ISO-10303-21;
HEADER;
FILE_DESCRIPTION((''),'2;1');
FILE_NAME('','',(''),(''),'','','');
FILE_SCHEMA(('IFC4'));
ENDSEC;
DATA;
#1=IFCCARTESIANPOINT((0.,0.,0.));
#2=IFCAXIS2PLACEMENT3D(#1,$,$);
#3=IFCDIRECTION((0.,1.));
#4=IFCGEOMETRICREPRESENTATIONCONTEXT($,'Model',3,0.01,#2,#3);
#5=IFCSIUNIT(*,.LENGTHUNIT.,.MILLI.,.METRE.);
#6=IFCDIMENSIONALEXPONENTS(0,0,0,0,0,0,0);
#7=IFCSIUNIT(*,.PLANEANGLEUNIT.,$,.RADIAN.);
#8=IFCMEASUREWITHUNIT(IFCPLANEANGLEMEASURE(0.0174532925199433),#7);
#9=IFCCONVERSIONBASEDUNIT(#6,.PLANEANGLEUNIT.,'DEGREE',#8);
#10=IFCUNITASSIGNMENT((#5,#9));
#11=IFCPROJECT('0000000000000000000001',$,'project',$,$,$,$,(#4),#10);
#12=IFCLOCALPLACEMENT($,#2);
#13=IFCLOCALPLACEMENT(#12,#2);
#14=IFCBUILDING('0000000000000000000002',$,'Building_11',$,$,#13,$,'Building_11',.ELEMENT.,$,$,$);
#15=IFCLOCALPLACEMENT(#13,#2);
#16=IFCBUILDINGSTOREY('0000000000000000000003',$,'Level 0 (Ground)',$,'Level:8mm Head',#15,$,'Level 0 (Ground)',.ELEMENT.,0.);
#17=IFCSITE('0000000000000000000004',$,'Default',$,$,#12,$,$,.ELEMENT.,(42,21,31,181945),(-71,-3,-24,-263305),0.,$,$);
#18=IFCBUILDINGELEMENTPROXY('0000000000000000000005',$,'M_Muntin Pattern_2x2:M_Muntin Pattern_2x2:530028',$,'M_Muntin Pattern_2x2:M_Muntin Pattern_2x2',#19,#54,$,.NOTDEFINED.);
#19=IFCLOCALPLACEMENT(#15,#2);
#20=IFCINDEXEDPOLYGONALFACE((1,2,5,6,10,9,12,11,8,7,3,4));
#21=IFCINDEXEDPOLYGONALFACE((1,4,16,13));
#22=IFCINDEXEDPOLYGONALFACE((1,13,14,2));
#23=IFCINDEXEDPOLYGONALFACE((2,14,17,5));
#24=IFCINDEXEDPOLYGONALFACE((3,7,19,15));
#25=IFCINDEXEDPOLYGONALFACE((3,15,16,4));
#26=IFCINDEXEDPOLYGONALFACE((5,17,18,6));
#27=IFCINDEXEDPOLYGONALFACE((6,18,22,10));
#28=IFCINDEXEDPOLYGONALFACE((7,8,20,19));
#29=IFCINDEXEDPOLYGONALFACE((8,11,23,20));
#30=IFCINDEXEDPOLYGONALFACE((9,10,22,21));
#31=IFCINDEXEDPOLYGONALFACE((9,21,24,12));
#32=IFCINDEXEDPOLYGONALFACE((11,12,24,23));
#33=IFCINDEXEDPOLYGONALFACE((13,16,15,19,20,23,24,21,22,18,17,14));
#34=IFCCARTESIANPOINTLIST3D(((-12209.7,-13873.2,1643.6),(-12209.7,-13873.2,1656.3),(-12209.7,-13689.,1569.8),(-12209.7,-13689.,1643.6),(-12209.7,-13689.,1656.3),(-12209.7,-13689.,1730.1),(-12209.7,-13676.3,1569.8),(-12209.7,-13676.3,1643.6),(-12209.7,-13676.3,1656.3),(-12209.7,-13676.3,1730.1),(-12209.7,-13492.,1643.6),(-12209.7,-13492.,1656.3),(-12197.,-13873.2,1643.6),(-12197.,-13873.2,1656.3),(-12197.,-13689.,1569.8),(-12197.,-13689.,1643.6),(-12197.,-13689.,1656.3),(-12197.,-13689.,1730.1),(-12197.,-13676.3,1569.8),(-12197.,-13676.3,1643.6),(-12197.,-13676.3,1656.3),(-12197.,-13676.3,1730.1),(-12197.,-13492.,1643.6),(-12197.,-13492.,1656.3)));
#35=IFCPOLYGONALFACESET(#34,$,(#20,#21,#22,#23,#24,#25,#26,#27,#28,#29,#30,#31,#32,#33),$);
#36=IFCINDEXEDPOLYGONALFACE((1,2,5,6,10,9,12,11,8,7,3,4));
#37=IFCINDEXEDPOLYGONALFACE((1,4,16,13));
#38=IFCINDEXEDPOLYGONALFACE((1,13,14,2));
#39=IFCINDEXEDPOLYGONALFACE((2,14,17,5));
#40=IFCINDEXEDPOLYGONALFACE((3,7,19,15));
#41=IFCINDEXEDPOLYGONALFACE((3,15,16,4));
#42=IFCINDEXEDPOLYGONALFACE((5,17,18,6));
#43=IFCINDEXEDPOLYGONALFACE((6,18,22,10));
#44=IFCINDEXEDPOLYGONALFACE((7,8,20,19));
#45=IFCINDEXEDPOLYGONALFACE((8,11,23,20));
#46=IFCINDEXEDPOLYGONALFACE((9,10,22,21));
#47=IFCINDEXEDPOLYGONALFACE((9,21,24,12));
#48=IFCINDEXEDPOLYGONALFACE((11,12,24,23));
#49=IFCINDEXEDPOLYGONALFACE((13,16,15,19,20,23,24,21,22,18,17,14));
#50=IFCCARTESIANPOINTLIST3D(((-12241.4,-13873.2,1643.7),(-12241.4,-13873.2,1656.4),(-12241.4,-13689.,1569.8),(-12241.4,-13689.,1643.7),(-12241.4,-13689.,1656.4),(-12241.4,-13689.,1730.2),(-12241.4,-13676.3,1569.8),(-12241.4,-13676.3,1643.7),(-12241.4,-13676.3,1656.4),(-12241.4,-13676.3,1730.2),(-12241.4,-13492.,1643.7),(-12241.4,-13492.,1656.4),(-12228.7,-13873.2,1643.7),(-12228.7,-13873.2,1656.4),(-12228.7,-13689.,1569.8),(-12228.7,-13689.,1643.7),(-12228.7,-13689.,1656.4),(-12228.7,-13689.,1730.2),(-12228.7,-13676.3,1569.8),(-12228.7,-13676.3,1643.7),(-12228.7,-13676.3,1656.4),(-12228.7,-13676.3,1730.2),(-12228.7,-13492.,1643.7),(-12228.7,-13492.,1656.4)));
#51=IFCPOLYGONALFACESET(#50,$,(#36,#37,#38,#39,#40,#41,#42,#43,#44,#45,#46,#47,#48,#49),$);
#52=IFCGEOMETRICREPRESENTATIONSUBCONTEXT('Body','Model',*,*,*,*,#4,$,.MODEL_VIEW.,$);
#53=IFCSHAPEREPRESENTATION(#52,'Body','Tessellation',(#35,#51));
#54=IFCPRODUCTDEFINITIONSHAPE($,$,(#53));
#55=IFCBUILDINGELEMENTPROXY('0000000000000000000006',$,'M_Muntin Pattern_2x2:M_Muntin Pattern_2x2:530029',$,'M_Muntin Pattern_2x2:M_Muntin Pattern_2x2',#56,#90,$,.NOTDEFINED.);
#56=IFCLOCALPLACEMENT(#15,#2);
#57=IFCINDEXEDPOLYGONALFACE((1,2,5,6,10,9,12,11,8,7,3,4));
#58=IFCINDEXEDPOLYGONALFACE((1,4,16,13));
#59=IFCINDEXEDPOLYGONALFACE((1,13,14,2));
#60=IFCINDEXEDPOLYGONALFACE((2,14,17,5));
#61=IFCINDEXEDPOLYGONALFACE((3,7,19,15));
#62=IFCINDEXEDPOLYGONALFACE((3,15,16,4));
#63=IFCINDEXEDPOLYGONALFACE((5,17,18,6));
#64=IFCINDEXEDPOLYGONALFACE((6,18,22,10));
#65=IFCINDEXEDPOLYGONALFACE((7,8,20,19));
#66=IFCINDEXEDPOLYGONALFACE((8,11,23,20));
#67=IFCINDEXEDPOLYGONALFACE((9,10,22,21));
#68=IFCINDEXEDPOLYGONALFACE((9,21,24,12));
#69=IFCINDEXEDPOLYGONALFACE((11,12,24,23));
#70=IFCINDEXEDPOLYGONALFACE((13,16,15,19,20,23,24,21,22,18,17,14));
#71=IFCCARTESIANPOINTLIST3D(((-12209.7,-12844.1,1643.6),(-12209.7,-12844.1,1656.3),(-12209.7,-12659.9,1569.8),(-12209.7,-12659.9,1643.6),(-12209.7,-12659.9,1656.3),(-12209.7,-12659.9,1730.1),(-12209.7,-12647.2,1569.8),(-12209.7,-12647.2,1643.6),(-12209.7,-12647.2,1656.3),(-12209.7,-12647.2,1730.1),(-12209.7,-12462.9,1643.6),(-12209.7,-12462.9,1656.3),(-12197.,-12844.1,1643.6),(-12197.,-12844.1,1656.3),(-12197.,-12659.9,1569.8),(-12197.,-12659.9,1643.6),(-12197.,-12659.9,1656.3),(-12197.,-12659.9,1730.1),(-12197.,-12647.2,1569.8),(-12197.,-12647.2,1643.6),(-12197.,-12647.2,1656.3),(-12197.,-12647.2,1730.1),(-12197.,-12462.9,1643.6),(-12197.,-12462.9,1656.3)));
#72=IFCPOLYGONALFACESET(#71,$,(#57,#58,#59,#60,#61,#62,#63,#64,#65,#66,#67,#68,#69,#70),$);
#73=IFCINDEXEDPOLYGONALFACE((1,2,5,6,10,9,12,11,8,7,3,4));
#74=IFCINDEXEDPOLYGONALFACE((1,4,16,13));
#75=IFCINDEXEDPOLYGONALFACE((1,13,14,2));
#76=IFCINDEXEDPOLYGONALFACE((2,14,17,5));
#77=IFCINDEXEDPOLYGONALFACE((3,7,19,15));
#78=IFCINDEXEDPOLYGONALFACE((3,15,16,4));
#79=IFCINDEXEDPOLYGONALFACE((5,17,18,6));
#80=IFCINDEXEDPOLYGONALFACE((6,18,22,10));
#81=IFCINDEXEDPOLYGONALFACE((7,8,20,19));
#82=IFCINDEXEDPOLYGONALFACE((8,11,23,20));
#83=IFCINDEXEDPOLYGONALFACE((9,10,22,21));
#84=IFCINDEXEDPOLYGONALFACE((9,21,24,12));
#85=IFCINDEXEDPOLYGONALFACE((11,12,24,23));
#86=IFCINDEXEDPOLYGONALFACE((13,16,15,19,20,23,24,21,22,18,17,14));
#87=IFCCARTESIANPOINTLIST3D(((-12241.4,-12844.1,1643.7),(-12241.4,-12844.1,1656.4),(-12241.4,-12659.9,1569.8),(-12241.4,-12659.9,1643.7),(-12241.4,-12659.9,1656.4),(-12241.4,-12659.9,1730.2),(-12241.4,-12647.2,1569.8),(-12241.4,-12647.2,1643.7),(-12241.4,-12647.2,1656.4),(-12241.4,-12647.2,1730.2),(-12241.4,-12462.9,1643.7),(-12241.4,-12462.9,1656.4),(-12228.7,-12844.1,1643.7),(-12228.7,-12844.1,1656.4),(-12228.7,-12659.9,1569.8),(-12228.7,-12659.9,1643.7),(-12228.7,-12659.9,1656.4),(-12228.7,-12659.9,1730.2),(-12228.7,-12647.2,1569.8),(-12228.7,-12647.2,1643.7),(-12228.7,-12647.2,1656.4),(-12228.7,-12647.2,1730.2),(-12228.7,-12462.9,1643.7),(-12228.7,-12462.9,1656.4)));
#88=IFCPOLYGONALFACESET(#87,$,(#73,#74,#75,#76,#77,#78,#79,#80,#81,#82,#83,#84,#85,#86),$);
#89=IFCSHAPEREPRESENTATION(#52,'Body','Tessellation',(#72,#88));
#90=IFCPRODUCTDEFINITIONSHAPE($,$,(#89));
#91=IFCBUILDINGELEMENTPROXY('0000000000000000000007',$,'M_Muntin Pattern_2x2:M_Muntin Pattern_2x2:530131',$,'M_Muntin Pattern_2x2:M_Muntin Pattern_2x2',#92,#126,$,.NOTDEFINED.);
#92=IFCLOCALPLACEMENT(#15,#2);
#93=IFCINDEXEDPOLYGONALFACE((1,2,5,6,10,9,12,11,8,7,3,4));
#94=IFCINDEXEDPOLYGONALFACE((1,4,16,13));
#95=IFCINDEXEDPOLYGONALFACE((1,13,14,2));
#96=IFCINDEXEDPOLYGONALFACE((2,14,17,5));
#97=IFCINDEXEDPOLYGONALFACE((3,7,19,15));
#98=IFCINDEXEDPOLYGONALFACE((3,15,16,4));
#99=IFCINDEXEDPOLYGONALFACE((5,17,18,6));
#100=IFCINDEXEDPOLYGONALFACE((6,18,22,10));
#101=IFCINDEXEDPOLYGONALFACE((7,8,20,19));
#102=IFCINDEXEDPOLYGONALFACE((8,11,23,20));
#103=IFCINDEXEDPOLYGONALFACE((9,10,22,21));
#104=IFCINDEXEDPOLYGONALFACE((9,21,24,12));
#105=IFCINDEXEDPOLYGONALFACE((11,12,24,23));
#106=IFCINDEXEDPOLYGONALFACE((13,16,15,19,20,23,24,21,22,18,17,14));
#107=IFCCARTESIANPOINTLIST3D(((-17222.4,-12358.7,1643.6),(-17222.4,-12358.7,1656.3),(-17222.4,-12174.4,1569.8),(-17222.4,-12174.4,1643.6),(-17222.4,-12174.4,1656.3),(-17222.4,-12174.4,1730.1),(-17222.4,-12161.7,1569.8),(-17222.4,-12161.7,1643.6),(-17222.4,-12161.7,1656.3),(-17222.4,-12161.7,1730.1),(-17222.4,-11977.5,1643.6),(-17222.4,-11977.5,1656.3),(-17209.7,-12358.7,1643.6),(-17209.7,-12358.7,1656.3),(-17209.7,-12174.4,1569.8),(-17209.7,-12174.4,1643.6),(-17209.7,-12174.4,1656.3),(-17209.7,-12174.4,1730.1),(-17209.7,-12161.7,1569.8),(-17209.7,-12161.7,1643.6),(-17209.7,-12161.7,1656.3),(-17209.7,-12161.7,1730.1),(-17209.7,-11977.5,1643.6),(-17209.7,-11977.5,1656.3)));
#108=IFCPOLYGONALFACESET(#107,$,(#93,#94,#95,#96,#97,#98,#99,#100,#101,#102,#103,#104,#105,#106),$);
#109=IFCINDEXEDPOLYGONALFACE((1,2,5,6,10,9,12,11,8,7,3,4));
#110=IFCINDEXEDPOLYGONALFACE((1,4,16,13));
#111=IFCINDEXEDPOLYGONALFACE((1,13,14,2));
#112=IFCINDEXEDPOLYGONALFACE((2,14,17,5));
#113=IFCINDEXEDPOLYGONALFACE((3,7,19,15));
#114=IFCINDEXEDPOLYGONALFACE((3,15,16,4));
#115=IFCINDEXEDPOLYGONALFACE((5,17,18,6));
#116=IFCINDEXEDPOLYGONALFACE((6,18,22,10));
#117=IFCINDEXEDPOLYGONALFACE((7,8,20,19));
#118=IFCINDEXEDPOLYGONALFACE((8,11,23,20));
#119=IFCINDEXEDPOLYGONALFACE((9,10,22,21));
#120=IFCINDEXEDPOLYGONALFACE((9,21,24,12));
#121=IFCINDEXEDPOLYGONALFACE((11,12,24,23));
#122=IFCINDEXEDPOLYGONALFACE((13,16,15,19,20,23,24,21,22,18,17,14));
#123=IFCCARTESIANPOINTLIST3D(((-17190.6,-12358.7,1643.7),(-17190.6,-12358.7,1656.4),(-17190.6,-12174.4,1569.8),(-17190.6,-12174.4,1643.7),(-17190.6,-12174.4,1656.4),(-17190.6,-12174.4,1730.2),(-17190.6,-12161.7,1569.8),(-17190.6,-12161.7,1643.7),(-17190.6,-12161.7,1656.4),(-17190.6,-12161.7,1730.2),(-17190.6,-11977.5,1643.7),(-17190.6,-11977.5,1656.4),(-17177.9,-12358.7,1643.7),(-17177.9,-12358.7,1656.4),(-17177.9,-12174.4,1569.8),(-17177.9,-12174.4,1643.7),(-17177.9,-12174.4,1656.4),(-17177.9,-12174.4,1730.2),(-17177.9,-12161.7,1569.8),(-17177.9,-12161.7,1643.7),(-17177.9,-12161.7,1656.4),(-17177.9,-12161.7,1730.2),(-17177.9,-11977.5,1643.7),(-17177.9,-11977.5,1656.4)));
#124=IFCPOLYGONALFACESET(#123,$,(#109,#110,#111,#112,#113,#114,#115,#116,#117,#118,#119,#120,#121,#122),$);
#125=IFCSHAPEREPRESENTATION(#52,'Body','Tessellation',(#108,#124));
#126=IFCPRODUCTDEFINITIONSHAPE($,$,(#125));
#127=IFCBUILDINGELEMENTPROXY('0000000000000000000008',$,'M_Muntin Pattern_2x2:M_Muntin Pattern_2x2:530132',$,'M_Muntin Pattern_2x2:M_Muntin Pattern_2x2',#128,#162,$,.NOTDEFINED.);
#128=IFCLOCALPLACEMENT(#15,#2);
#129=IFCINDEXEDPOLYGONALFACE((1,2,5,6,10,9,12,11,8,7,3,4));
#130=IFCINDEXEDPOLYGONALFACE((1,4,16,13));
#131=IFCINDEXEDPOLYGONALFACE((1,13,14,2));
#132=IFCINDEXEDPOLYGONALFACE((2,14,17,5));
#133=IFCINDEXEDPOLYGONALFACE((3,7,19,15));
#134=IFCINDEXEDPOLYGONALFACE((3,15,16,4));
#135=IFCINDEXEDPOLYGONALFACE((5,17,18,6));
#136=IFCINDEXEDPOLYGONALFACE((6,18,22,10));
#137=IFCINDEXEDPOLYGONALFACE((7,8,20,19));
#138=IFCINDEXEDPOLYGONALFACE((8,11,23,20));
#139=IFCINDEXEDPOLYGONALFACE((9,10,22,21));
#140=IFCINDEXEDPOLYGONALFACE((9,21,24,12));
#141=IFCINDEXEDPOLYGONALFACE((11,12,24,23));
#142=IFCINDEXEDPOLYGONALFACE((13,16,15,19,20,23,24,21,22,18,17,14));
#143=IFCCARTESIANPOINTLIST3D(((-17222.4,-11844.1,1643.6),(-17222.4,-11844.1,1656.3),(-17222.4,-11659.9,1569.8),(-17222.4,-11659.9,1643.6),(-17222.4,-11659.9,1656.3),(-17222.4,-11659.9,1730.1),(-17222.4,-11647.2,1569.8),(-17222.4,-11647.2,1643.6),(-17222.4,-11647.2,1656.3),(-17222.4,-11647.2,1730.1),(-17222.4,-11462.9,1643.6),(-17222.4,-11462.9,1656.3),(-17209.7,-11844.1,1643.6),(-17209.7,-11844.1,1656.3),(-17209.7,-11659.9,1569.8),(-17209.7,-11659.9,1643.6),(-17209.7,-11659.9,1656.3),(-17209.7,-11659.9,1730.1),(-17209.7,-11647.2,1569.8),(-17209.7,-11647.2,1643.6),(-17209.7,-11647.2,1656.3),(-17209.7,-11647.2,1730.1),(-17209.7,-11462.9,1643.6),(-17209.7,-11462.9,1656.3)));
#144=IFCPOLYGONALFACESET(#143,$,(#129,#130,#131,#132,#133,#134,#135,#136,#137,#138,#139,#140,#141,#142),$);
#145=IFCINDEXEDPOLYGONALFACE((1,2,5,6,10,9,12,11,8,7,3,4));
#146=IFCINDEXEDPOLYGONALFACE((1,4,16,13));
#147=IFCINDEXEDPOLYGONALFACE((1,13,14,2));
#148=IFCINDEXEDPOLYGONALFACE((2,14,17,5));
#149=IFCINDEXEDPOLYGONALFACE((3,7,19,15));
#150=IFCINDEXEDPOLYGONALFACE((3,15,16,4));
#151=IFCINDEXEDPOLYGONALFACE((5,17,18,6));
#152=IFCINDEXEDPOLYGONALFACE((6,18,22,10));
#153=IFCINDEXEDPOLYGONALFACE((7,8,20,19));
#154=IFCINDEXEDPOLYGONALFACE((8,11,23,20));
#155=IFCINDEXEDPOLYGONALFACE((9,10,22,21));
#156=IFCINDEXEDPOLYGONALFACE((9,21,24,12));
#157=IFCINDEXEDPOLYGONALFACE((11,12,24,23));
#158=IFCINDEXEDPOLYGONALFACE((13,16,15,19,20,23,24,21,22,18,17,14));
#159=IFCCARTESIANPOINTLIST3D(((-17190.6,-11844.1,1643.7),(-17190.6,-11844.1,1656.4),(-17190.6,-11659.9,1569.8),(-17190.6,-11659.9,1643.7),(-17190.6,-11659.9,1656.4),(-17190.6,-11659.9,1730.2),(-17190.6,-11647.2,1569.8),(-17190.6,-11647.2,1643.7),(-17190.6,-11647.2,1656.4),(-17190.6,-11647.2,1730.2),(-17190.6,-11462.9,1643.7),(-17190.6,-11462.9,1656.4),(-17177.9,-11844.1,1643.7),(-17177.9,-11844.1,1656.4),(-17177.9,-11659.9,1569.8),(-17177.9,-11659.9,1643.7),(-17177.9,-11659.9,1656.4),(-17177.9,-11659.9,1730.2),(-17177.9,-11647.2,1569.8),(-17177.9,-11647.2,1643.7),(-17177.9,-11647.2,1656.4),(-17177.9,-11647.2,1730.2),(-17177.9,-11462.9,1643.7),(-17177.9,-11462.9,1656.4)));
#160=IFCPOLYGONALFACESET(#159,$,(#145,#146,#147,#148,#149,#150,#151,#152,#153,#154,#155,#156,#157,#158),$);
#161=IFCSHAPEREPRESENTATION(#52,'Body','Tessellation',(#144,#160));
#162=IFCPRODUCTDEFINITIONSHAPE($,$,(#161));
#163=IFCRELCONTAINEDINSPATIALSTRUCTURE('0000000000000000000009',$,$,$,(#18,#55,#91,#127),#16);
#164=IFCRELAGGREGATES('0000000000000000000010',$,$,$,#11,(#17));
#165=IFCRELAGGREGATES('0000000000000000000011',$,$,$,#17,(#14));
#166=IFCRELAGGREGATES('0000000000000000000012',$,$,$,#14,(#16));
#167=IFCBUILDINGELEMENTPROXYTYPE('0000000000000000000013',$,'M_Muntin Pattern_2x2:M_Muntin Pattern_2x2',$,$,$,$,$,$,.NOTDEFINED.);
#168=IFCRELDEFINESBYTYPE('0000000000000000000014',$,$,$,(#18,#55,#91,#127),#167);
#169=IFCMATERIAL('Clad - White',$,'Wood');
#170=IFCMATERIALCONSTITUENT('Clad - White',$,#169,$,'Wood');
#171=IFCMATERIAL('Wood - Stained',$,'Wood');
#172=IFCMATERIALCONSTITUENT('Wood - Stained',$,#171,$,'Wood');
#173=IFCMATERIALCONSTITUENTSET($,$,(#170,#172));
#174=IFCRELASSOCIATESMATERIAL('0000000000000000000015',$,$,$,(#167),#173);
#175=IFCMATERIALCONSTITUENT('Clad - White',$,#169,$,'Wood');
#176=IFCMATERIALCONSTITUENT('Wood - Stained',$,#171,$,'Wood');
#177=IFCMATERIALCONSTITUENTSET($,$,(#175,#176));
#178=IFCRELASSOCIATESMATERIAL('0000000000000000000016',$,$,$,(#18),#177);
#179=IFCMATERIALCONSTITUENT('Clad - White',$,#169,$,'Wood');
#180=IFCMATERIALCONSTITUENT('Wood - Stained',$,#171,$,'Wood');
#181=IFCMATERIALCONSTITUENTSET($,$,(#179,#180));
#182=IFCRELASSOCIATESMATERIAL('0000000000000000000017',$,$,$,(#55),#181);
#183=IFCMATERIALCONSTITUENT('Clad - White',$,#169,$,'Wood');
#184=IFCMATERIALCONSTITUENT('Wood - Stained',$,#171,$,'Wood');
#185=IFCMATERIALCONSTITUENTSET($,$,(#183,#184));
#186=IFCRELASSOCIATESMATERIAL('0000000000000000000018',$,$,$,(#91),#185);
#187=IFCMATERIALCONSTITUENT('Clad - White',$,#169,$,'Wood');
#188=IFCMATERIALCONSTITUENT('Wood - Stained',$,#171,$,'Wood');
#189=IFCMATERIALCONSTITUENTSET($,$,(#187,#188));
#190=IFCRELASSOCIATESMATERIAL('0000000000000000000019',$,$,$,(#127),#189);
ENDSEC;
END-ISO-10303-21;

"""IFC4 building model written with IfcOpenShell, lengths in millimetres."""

from ifc_helpers import new_model, entity, si_unit, converted_unit, direction, frame, origin, place, context, subcontext, project, spatial, indexed_curve, outline, extrude, source, transform, mapped, material, constituent, constituent_set, type_object, type_shapes, element, save


model = new_model("IFC4")

# Units and contexts
model_context = context("Model", 3, precision=0.01, world=origin(), true_north=direction((0.0, 1.0)))
body_context = subcontext(model_context, "Body", "Model", "MODEL_VIEW")
ifc_project = project(units=[si_unit("LENGTHUNIT", "METRE", prefix="MILLI"), converted_unit("PLANEANGLEUNIT", "DEGREE", entity("IfcPlaneAngleMeasure", 0.0174532925199433), si_unit("PLANEANGLEUNIT", "RADIAN"), dimensions=[0, 0, 0, 0, 0, 0, 0])], contexts=[model_context])

# Site, building, storey
site_placement = place(None, origin())
site = spatial("IfcSite", under=ifc_project, at=site_placement, Name="Default", CompositionType="ELEMENT", RefLatitude=(42, 21, 31, 181945), RefLongitude=(-71, -3, -24, -263305), RefElevation=0.0)
building_placement = place(site_placement, origin())
building = spatial("IfcBuilding", under=site, at=building_placement, Name="Building_11", LongName="Building_11", CompositionType="ELEMENT")
storey_placement = place(building_placement, origin())
storey = spatial("IfcBuildingStorey", under=building, at=storey_placement, Name="Level 0 (Ground)", ObjectType="Level:8mm Head", LongName="Level 0 (Ground)", CompositionType="ELEMENT", Elevation=0.0)

# Building element proxies
ifc_material_1 = material(Name="Clad - White", Category="Wood")
ifc_material_2 = material(Name="Wood - Stained", Category="Wood")
ifc_constituent_1 = constituent(ifc_material_1, Name="Clad - White", Category="Wood")
ifc_constituent_2 = constituent(ifc_material_2, Name="Wood - Stained", Category="Wood")
ifc_constituent_set_1 = constituent_set(constituents=[ifc_constituent_1, ifc_constituent_2])
building_element_proxy_type_1 = type_object("IfcBuildingElementProxyType", Name="M_Muntin Pattern_2x2:M_Muntin Pattern_2x2", PredefinedType="NOTDEFINED", material=ifc_constituent_set_1)
shared_shape_1 = source(origin(), body_context, "Body", "SweptSolid", [
    extrude(outline(indexed_curve([(6.4, -6.4), (80.1, -6.4), (80.1, 6.3), (6.4, 6.3), (6.4, 190.6), (-6.3, 190.6), (-6.3, 6.3), (-80.2, 6.3), (-80.2, -6.4), (-6.3, -6.4), (-6.3, -190.6), (6.4, -190.6), (6.4, -6.4)], self_intersect=False)), frame((0.0, 9.5, 80.1), z_axis=(0.0, 1.0, 0.0), x_axis=(0.0, 0.0, 1.0)), (0.0, 0.0, 1.0), 12.7),
    extrude(outline(indexed_curve([(6.4, -6.4), (80.2, -6.4), (80.2, 6.3), (6.4, 6.3), (6.4, 190.6), (-6.3, 190.6), (-6.3, 6.3), (-80.2, 6.3), (-80.2, -6.4), (-6.3, -6.4), (-6.3, -190.6), (6.4, -190.6), (6.4, -6.4)], self_intersect=False)), frame((0.0, -22.2, 80.2), z_axis=(0.0, 1.0, 0.0), x_axis=(0.0, 0.0, 1.0)), (0.0, 0.0, 1.0), 12.7),
])
type_shapes(building_element_proxy_type_1, [shared_shape_1])
ifc_constituent_3 = constituent(ifc_material_1, Name="Clad - White", Category="Wood")
ifc_constituent_4 = constituent(ifc_material_2, Name="Wood - Stained", Category="Wood")
ifc_constituent_set_2 = constituent_set(constituents=[ifc_constituent_3, ifc_constituent_4])
proxy_1_placement = place(storey_placement, frame((-12219.2, -13682.6, 1569.8), z_axis=(0.0, 0.0, 1.0), x_axis=(0.0, -1.0, 0.0)))
element("IfcBuildingElementProxy", 1, at=proxy_1_placement, inside=storey, type_object=building_element_proxy_type_1, material=ifc_constituent_set_2, Name="M_Muntin Pattern_2x2:M_Muntin Pattern_2x2:530028", ObjectType="M_Muntin Pattern_2x2:M_Muntin Pattern_2x2", PredefinedType="NOTDEFINED", context=body_context, shape_type="MappedRepresentation", body=[
    mapped(shared_shape_1, transform((0.0, 0.0, 0.0), scale=1.0)),
])
ifc_constituent_5 = constituent(ifc_material_1, Name="Clad - White", Category="Wood")
ifc_constituent_6 = constituent(ifc_material_2, Name="Wood - Stained", Category="Wood")
ifc_constituent_set_3 = constituent_set(constituents=[ifc_constituent_5, ifc_constituent_6])
proxy_2_placement = place(storey_placement, frame((-12219.2, -12653.5, 1569.8), z_axis=(0.0, 0.0, 1.0), x_axis=(0.0, -1.0, 0.0)))
element("IfcBuildingElementProxy", 2, at=proxy_2_placement, inside=storey, type_object=building_element_proxy_type_1, material=ifc_constituent_set_3, Name="M_Muntin Pattern_2x2:M_Muntin Pattern_2x2:530029", ObjectType="M_Muntin Pattern_2x2:M_Muntin Pattern_2x2", PredefinedType="NOTDEFINED", context=body_context, shape_type="MappedRepresentation", body=[
    mapped(shared_shape_1, transform((0.0, 0.0, 0.0), scale=1.0)),
])
ifc_constituent_7 = constituent(ifc_material_1, Name="Clad - White", Category="Wood")
ifc_constituent_8 = constituent(ifc_material_2, Name="Wood - Stained", Category="Wood")
ifc_constituent_set_4 = constituent_set(constituents=[ifc_constituent_7, ifc_constituent_8])
proxy_3_placement = place(storey_placement, frame((-17200.2, -12168.1, 1569.8), z_axis=(0.0, 0.0, 1.0), x_axis=(0.0, 1.0, 0.0)))
element("IfcBuildingElementProxy", 3, at=proxy_3_placement, inside=storey, type_object=building_element_proxy_type_1, material=ifc_constituent_set_4, Name="M_Muntin Pattern_2x2:M_Muntin Pattern_2x2:530131", ObjectType="M_Muntin Pattern_2x2:M_Muntin Pattern_2x2", PredefinedType="NOTDEFINED", context=body_context, shape_type="MappedRepresentation", body=[
    mapped(shared_shape_1, transform((0.0, 0.0, 0.0), scale=1.0)),
])
ifc_constituent_9 = constituent(ifc_material_1, Name="Clad - White", Category="Wood")
ifc_constituent_10 = constituent(ifc_material_2, Name="Wood - Stained", Category="Wood")
ifc_constituent_set_5 = constituent_set(constituents=[ifc_constituent_9, ifc_constituent_10])
proxy_4_placement = place(storey_placement, frame((-17200.2, -11653.5, 1569.8), z_axis=(0.0, 0.0, 1.0), x_axis=(0.0, 1.0, 0.0)))
element("IfcBuildingElementProxy", 4, at=proxy_4_placement, inside=storey, type_object=building_element_proxy_type_1, material=ifc_constituent_set_5, Name="M_Muntin Pattern_2x2:M_Muntin Pattern_2x2:530132", ObjectType="M_Muntin Pattern_2x2:M_Muntin Pattern_2x2", PredefinedType="NOTDEFINED", context=body_context, shape_type="MappedRepresentation", body=[
    mapped(shared_shape_1, transform((0.0, 0.0, 0.0), scale=1.0)),
])

save(model, "model.ifc")
